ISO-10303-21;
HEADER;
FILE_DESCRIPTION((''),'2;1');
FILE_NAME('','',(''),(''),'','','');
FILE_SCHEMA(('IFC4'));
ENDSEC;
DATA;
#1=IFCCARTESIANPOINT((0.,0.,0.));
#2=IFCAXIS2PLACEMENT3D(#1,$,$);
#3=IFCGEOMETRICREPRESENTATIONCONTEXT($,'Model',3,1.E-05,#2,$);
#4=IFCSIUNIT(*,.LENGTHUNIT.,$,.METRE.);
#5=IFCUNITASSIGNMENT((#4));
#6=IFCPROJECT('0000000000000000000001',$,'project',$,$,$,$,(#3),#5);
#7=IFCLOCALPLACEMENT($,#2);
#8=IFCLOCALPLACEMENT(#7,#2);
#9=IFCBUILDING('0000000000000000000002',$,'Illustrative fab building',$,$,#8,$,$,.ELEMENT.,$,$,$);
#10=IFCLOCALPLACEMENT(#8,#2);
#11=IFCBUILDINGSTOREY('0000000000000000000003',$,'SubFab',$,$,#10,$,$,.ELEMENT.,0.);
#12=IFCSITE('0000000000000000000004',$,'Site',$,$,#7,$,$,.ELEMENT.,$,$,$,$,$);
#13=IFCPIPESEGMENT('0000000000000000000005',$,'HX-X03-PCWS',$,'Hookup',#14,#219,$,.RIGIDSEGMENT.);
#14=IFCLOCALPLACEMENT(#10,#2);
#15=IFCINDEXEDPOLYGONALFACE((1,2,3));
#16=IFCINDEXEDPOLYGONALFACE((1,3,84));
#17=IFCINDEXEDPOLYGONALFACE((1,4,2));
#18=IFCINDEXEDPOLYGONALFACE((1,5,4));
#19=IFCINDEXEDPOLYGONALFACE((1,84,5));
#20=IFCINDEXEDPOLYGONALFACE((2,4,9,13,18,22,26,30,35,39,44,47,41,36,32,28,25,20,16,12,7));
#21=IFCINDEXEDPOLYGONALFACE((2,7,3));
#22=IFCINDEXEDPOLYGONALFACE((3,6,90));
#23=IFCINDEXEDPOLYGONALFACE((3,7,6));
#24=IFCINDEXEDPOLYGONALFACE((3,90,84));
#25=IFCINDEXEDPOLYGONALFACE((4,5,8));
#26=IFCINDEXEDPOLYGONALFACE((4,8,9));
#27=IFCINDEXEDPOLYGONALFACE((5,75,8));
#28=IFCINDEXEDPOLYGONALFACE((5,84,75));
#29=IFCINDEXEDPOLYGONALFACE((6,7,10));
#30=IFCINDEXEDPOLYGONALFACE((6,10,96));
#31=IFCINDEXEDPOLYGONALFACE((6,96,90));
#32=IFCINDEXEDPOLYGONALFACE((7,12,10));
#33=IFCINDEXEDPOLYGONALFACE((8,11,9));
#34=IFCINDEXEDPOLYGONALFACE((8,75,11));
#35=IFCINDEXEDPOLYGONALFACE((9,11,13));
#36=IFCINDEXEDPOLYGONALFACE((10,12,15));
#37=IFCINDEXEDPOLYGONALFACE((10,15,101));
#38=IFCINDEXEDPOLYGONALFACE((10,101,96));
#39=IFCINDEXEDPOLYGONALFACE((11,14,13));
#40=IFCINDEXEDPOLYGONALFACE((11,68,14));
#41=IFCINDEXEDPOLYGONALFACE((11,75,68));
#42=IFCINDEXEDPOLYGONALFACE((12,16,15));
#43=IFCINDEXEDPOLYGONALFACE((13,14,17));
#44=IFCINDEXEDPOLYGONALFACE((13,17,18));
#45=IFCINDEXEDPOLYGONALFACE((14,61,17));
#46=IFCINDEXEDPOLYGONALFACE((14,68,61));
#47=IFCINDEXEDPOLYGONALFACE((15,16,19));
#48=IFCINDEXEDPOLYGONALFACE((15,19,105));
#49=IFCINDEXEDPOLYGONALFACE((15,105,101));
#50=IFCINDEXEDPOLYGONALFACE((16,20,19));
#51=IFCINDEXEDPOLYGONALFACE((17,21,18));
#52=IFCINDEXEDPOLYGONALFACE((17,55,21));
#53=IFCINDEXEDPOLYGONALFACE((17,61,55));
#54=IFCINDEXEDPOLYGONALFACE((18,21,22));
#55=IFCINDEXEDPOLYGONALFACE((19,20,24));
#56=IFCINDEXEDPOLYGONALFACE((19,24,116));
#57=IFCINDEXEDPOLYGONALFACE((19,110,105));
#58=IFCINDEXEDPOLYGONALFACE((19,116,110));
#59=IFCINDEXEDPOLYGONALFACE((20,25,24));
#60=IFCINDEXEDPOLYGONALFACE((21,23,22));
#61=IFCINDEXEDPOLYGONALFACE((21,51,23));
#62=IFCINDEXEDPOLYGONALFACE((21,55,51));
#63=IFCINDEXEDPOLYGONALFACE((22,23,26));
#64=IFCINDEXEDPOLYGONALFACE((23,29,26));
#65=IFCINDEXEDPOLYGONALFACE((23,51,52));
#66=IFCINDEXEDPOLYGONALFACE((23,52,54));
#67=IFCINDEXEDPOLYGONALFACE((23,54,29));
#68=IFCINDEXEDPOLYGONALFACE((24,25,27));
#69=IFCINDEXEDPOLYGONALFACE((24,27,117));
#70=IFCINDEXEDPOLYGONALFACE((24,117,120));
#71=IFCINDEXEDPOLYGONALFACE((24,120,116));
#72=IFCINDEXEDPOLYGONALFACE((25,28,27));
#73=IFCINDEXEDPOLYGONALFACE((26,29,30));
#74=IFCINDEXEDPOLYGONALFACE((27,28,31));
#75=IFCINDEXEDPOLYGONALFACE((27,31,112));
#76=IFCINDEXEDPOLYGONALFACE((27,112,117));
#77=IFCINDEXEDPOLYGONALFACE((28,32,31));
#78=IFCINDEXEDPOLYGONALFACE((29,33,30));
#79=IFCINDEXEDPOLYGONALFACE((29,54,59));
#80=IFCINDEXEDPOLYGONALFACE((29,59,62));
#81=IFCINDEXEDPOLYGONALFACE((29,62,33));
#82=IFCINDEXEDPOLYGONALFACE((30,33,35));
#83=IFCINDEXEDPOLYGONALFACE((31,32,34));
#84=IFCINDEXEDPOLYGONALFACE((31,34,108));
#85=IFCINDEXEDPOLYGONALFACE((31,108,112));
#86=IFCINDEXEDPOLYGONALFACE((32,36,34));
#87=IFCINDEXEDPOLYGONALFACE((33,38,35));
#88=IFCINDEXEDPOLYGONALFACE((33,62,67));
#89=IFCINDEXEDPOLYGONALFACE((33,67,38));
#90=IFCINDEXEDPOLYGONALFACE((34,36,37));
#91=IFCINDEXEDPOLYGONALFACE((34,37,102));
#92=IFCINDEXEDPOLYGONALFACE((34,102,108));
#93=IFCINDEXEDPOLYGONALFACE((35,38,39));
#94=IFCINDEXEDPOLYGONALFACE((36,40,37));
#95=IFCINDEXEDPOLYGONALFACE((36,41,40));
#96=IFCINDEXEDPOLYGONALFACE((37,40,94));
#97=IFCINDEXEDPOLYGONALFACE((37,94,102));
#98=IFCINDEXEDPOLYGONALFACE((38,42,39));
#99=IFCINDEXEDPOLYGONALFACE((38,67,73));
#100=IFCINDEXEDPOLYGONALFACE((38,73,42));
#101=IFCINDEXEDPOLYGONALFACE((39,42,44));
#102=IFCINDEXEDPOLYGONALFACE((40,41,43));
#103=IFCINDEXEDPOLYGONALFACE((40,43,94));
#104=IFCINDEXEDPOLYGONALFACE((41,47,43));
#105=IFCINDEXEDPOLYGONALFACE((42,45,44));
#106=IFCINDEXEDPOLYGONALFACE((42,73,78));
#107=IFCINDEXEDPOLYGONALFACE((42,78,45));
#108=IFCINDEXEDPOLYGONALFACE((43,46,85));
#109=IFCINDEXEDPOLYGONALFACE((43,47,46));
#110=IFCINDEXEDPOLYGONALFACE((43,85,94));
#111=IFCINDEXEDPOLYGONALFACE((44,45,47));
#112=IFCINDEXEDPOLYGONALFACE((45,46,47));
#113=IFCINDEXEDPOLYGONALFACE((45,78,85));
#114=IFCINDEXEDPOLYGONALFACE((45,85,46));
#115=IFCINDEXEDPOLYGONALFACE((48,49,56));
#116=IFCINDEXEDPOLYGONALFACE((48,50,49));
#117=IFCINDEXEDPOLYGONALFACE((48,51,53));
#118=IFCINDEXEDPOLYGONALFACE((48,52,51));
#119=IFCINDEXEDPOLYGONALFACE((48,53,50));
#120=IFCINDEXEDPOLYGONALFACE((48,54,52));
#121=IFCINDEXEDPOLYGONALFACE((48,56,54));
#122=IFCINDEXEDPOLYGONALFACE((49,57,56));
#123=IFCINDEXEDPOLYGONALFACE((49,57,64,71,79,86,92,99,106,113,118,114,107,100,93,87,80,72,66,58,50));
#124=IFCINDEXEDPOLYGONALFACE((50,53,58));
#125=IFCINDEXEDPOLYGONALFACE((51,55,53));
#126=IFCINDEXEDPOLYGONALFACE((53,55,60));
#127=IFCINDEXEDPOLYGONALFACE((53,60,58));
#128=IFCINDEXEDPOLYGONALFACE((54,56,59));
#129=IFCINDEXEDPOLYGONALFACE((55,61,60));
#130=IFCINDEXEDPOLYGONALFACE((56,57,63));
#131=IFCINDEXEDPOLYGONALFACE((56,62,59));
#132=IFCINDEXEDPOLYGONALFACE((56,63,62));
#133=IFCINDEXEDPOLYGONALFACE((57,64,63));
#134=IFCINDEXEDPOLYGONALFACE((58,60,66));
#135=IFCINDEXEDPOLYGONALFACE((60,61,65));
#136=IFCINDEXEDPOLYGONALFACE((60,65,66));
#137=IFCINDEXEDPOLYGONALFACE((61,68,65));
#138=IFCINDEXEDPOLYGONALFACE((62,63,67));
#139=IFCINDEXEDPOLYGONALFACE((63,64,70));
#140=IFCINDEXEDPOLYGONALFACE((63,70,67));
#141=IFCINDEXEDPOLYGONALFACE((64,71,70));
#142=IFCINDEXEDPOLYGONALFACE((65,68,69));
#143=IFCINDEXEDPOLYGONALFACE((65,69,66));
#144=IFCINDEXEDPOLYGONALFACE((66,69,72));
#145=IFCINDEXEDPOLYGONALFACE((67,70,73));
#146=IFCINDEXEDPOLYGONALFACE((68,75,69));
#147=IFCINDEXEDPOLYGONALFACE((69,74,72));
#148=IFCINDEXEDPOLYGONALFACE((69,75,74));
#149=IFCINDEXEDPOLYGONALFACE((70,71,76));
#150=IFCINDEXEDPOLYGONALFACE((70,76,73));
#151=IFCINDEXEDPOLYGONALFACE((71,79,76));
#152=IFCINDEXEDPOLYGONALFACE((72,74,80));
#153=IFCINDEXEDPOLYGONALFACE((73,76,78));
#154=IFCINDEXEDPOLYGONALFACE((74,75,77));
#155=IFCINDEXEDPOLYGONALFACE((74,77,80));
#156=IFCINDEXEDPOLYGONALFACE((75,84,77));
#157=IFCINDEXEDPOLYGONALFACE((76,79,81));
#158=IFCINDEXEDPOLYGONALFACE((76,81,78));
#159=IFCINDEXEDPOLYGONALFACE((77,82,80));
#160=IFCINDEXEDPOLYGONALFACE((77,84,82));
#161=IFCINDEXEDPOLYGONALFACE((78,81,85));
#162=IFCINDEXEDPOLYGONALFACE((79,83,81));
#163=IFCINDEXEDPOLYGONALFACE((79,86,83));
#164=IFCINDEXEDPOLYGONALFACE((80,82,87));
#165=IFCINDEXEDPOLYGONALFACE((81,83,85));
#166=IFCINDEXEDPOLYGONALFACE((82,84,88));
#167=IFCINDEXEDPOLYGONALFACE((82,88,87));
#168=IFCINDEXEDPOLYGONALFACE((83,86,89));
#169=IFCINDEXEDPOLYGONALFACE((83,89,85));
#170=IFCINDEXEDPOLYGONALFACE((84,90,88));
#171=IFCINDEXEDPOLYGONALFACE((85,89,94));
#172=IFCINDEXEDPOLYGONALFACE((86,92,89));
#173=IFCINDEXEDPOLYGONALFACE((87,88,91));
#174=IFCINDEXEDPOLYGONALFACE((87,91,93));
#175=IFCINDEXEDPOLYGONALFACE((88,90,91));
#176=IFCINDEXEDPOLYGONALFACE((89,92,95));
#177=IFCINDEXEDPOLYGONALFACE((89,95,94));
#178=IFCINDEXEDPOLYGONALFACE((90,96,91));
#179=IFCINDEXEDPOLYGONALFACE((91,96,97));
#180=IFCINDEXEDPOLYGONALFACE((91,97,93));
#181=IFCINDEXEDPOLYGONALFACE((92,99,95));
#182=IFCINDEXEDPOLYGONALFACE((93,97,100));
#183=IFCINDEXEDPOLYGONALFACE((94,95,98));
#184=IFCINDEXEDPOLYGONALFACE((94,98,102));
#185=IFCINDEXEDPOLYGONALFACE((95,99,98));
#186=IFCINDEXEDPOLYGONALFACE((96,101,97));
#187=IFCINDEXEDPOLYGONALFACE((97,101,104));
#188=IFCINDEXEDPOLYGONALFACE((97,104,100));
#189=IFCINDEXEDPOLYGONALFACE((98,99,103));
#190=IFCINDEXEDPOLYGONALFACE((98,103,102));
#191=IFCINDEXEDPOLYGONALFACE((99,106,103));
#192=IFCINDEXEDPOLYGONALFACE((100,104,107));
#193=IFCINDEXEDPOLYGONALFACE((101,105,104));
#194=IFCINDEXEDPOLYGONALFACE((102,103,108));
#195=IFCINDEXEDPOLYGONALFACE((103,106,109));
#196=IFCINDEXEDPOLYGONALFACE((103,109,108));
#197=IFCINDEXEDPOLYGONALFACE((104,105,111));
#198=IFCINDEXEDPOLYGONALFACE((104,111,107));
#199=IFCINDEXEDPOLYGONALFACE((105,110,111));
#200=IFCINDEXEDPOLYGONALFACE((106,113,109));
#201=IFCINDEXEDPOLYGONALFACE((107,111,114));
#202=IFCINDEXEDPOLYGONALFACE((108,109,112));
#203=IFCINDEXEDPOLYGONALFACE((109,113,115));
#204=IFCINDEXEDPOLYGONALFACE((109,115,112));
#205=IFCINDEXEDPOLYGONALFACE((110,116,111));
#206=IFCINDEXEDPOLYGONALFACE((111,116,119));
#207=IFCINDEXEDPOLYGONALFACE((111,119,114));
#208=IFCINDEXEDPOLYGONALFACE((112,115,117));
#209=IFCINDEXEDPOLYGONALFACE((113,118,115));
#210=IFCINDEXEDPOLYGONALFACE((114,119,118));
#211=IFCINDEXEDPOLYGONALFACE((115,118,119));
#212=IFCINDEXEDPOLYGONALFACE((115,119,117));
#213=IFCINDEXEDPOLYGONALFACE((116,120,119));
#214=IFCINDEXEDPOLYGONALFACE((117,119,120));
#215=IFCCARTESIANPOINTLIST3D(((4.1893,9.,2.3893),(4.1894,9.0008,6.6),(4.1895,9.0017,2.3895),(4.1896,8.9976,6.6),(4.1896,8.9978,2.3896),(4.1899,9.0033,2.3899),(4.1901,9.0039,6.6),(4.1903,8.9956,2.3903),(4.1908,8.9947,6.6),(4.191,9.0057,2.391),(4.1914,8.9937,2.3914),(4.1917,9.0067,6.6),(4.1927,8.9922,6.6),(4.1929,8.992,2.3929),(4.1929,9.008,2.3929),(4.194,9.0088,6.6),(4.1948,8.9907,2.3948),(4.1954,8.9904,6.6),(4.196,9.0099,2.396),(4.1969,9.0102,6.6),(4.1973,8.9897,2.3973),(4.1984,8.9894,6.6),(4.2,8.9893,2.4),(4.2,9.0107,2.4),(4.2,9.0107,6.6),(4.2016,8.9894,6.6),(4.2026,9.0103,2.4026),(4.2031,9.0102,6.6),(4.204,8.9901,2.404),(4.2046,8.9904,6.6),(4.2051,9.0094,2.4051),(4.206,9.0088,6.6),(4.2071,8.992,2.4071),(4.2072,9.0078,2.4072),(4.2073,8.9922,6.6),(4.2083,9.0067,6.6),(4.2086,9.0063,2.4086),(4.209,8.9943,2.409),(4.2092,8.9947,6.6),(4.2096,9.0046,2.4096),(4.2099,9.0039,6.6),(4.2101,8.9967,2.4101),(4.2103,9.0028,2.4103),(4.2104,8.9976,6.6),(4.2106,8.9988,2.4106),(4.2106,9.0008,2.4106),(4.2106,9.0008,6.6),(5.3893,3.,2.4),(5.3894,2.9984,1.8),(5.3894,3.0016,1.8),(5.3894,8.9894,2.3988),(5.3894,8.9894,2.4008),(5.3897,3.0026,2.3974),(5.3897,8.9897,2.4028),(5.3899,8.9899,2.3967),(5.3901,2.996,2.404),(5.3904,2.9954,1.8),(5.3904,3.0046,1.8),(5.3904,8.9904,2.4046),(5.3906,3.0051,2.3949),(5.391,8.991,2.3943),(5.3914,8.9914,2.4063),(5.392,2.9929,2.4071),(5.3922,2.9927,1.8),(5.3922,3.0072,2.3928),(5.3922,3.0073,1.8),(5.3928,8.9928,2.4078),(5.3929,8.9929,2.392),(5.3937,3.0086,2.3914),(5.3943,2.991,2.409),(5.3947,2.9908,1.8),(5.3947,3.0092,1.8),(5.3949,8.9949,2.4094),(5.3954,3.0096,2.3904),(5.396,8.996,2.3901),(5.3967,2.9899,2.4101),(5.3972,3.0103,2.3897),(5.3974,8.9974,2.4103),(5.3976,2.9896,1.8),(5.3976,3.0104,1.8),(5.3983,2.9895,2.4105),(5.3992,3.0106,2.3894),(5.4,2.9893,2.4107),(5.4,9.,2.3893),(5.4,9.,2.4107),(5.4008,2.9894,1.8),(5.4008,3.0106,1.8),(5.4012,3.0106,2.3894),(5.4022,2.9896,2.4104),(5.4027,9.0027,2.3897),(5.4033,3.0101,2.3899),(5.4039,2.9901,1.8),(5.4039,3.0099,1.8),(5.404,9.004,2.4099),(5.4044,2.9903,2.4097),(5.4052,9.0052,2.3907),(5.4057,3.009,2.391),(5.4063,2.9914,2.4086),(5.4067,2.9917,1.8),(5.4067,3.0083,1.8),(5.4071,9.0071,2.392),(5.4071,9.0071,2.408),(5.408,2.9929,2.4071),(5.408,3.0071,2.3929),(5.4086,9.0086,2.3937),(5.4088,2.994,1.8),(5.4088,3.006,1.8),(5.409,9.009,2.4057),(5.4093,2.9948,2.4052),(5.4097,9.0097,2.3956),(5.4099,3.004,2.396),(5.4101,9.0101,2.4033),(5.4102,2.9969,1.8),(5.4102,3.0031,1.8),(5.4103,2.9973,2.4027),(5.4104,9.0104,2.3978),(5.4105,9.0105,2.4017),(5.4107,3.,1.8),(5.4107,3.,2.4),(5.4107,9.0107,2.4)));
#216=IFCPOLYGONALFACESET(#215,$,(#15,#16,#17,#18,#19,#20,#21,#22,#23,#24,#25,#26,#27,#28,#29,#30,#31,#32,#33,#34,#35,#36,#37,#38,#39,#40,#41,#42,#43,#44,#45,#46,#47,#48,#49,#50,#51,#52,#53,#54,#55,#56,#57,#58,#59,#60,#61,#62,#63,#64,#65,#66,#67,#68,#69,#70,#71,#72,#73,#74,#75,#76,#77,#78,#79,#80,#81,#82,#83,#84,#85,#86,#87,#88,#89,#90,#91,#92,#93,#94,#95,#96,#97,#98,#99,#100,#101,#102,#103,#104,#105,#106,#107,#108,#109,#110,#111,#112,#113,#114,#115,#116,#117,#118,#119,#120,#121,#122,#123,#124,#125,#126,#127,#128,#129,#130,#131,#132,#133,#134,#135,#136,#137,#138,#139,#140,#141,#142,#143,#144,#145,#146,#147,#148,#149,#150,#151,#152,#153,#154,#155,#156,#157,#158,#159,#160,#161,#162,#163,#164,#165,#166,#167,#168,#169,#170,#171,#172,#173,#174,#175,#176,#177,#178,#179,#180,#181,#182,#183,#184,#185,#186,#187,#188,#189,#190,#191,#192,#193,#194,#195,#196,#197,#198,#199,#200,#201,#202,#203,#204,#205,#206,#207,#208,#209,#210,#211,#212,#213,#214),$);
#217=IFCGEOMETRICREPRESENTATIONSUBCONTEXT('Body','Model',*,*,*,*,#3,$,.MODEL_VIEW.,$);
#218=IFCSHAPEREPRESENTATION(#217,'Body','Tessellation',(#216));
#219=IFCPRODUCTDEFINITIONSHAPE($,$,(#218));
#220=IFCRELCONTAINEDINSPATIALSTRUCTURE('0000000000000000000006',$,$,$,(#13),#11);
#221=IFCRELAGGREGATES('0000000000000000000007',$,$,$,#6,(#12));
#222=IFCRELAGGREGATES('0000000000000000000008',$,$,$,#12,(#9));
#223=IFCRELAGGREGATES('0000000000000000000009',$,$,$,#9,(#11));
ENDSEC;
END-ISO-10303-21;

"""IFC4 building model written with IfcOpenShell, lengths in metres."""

from ifc_helpers import new_model, entity, si_unit, origin, place, context, subcontext, project, spatial, element, save


model = new_model("IFC4")

# Units and contexts
model_context = context("Model", 3, precision=1e-05, world=origin())
body_context = subcontext(model_context, "Body", "Model", "MODEL_VIEW")
ifc_project = project(units=[si_unit("LENGTHUNIT", "METRE")], contexts=[model_context])

# Site, building, storey
site_placement = place(None, origin())
site = spatial("IfcSite", under=ifc_project, at=site_placement, Name="Site", CompositionType="ELEMENT")
building_placement = place(site_placement, origin())
building = spatial("IfcBuilding", under=site, at=building_placement, Name="Illustrative fab building", CompositionType="ELEMENT")
storey_placement = place(building_placement, origin())
storey = spatial("IfcBuildingStorey", under=building, at=storey_placement, Name="SubFab", CompositionType="ELEMENT", Elevation=0.0)

# Pipe segment
pipe_segment_1_placement = place(storey_placement, origin())
element("IfcPipeSegment", 1, at=pipe_segment_1_placement, inside=storey, Name="HX-X03-PCWS", ObjectType="Hookup", PredefinedType="RIGIDSEGMENT", context=body_context, shape_type="AdvancedSweptSolid", body=[
    entity("IfcSweptDiskSolid", entity("IfcPolyline", [entity("IfcCartesianPoint", [5.4, 3.0, 1.8]), entity("IfcCartesianPoint", [5.4, 3.0, 2.4]), entity("IfcCartesianPoint", [5.4, 9.0, 2.4]), entity("IfcCartesianPoint", [4.2, 9.0, 2.4]), entity("IfcCartesianPoint", [4.2, 9.0, 6.6])]), 0.0107),
])

save(model, "model.ifc")
